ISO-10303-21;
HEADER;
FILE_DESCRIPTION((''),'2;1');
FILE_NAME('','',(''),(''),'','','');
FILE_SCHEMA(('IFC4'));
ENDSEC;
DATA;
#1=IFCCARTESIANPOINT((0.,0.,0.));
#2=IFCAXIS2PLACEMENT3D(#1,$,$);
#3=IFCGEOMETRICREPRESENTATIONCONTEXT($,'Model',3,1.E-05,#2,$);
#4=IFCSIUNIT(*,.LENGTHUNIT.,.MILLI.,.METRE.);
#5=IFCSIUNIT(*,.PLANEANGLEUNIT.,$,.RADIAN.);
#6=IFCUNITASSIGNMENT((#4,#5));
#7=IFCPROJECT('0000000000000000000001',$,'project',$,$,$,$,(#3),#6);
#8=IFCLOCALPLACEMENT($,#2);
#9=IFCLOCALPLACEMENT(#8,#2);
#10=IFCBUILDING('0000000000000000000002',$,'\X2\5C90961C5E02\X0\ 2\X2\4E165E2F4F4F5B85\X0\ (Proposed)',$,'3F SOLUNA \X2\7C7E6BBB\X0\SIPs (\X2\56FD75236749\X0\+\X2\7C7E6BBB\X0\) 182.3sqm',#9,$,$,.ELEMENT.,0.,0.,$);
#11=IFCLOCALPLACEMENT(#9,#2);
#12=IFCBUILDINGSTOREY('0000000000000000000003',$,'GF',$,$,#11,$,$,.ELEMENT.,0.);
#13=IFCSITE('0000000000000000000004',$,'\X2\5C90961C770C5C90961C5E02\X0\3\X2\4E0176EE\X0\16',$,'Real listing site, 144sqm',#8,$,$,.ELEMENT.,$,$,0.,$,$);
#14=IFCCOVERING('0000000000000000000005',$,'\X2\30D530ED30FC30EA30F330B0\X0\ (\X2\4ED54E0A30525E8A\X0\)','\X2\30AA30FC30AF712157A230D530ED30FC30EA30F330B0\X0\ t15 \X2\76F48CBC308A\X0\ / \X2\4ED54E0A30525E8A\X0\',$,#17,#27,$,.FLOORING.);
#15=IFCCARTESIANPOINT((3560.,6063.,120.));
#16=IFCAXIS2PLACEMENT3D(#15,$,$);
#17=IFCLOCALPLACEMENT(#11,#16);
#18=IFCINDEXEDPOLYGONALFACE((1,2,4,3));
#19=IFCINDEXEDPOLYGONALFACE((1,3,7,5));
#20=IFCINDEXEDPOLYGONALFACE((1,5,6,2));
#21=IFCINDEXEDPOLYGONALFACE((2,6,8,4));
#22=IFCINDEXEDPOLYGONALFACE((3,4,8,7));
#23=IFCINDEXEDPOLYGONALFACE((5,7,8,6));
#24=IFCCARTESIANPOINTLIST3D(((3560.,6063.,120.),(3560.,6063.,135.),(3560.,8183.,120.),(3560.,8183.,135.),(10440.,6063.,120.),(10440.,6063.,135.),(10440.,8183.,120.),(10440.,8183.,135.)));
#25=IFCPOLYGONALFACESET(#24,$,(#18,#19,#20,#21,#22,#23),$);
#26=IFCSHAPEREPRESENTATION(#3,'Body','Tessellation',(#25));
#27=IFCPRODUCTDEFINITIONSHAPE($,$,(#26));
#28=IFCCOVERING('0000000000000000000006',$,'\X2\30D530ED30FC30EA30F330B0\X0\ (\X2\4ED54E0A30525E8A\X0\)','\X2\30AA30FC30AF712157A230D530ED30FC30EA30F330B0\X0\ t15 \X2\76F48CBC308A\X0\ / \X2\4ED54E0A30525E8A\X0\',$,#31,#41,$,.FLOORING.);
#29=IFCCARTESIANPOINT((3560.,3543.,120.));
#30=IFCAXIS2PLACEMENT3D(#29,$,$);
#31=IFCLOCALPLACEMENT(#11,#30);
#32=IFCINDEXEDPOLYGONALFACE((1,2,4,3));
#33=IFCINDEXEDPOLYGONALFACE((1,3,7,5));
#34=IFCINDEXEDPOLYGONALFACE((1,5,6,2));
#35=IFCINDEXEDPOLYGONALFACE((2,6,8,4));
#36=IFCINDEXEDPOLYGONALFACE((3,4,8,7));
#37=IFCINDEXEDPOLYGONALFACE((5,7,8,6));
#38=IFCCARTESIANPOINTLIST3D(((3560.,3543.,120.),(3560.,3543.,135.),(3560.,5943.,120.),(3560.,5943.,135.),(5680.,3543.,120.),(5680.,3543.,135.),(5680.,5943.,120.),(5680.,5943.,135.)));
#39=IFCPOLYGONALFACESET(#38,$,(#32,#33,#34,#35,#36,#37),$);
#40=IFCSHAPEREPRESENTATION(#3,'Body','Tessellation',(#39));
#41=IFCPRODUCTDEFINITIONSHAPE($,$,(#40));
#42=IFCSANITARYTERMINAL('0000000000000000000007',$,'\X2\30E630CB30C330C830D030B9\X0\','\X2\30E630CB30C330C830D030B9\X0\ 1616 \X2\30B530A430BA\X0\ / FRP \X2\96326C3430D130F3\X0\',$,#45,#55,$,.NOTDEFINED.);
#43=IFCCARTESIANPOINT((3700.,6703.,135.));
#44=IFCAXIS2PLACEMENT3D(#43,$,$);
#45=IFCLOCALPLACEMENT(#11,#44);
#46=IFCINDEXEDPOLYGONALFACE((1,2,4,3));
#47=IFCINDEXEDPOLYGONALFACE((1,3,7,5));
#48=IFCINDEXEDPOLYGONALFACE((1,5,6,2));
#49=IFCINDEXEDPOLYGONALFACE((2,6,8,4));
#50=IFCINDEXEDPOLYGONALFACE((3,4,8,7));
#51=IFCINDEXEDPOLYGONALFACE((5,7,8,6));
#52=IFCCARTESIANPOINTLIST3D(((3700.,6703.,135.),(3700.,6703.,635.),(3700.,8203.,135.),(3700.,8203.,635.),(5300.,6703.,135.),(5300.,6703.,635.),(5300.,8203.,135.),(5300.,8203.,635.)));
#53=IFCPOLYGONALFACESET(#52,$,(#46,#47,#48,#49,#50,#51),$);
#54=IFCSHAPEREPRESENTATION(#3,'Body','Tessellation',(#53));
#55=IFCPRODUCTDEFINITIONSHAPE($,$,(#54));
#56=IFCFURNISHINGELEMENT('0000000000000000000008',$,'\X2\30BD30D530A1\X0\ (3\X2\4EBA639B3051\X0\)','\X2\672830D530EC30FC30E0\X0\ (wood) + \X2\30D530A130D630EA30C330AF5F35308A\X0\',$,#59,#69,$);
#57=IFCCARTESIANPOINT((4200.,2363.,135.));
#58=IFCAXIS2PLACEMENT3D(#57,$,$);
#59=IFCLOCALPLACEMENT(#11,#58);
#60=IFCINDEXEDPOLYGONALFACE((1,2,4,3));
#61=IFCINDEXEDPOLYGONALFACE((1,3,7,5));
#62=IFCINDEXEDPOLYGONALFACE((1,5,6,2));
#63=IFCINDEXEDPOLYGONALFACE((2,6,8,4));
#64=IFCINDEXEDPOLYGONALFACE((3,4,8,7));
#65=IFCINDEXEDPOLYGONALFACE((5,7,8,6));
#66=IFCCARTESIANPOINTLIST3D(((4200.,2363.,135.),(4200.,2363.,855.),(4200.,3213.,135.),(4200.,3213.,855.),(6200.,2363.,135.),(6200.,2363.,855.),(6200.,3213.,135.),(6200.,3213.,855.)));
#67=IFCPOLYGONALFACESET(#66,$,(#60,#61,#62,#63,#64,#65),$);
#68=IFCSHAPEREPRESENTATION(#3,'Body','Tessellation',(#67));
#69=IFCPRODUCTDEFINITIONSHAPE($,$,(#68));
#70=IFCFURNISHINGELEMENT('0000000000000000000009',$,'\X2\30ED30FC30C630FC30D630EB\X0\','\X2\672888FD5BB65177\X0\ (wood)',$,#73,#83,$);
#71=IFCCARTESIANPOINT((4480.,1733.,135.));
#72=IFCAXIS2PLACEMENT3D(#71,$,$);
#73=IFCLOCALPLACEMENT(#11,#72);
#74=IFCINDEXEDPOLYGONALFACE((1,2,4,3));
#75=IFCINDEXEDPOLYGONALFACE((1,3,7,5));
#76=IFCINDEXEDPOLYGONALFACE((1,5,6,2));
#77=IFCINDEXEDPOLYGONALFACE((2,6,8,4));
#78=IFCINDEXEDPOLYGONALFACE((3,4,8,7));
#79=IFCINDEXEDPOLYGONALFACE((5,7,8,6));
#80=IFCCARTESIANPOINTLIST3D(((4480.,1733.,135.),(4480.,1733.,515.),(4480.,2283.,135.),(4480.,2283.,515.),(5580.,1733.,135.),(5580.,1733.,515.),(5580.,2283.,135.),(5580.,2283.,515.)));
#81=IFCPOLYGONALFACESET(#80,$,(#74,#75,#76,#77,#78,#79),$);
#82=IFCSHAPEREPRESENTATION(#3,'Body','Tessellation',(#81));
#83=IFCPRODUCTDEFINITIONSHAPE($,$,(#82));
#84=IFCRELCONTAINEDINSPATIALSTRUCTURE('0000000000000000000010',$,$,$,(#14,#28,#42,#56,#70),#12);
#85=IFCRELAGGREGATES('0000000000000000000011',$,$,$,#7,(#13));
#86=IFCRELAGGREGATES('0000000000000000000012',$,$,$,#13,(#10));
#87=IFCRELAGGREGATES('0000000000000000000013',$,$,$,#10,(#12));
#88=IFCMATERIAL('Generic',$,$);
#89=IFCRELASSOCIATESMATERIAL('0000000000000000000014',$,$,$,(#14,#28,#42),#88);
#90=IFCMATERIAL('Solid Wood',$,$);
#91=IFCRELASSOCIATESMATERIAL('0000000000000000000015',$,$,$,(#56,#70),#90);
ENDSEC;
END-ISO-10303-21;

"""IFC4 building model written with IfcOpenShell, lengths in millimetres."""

from ifc_helpers import new_model, si_unit, frame, frame_2d, origin, place, context, project, spatial, rectangle, extrude, material, element, save


model = new_model("IFC4")

# Units and contexts
model_context = context("Model", 3, precision=1e-05, world=origin())
ifc_project = project(units=[si_unit("LENGTHUNIT", "METRE", prefix="MILLI"), si_unit("PLANEANGLEUNIT", "RADIAN")], contexts=[model_context])

# Site, building, storey
site_placement = place(None, origin())
site = spatial("IfcSite", under=ifc_project, at=site_placement, Name="岐阜県岐阜市3丁目16", ObjectType="Real listing site, 144sqm", CompositionType="ELEMENT", RefElevation=0.0)
building_placement = place(site_placement, origin())
building = spatial("IfcBuilding", under=site, at=building_placement, Name="岐阜市 2世帯住宅 (Proposed)", ObjectType="3F SOLUNA 籾殻SIPs (国産杉+籾殻) 182.3sqm", CompositionType="ELEMENT", ElevationOfRefHeight=0.0, ElevationOfTerrain=0.0)
storey_placement = place(building_placement, origin())
storey = spatial("IfcBuildingStorey", under=building, at=storey_placement, Name="GF", CompositionType="ELEMENT", Elevation=0.0)

# Shared definitions
ifc_material_1 = material(Name="Solid Wood")

# Coverings
ifc_material_2 = material(Name="Generic")
covering_1_placement = place(storey_placement, frame((3560.0, 6063.0, 120.0)))
element("IfcCovering", 1, at=covering_1_placement, inside=storey, material=ifc_material_2, Name="フローリング (仕上げ床)", Description="オーク無垢フローリング t15 直貼り / 仕上げ床", PredefinedType="FLOORING", context=model_context, shape_type="SweptSolid", body=[
    extrude(rectangle(XDim=6880.0, YDim=2120.0, at=frame_2d((3440.0, 1060.0))), frame((3560.0, 6063.0, 120.0)), (0.0, 0.0, 1.0), 15.0),
])
covering_2_placement = place(storey_placement, frame((3560.0, 3543.0, 120.0)))
element("IfcCovering", 2, at=covering_2_placement, inside=storey, material=ifc_material_2, Name="フローリング (仕上げ床)", Description="オーク無垢フローリング t15 直貼り / 仕上げ床", PredefinedType="FLOORING", context=model_context, shape_type="SweptSolid", body=[
    extrude(rectangle(XDim=2120.0, YDim=2400.0, at=frame_2d((1060.0, 1200.0))), frame((3560.0, 3543.0, 120.0)), (0.0, 0.0, 1.0), 15.0),
])

# Sanitary terminal
sanitary_terminal_placement = place(storey_placement, frame((3700.0, 6703.0, 135.0)))
element("IfcSanitaryTerminal", 3, at=sanitary_terminal_placement, inside=storey, material=ifc_material_2, Name="ユニットバス", Description="ユニットバス 1616 サイズ / FRP 防水パン", PredefinedType="NOTDEFINED", context=model_context, shape_type="SweptSolid", body=[
    extrude(rectangle(XDim=1600.0, YDim=1500.0, at=frame_2d((800.0, 750.0))), frame((3700.0, 6703.0, 135.0)), (0.0, 0.0, 1.0), 500.0),
])

# Furnishing elements
furnishing_1_placement = place(storey_placement, frame((4200.0, 2363.0, 135.0)))
element("IfcFurnishingElement", 4, at=furnishing_1_placement, inside=storey, material=ifc_material_1, Name="ソファ (3人掛け)", Description="木フレーム (wood) + ファブリック張り", context=model_context, shape_type="SweptSolid", body=[
    extrude(rectangle(XDim=2000.0, YDim=850.0, at=frame_2d((1000.0, 425.0))), frame((4200.0, 2363.0, 135.0)), (0.0, 0.0, 1.0), 720.0),
])
furnishing_2_placement = place(storey_placement, frame((4480.0, 1733.0, 135.0)))
element("IfcFurnishingElement", 5, at=furnishing_2_placement, inside=storey, material=ifc_material_1, Name="ローテーブル", Description="木製家具 (wood)", context=model_context, shape_type="SweptSolid", body=[
    extrude(rectangle(XDim=1100.0, YDim=550.0, at=frame_2d((550.0, 275.0))), frame((4480.0, 1733.0, 135.0)), (0.0, 0.0, 1.0), 380.0),
])

save(model, "model.ifc")
